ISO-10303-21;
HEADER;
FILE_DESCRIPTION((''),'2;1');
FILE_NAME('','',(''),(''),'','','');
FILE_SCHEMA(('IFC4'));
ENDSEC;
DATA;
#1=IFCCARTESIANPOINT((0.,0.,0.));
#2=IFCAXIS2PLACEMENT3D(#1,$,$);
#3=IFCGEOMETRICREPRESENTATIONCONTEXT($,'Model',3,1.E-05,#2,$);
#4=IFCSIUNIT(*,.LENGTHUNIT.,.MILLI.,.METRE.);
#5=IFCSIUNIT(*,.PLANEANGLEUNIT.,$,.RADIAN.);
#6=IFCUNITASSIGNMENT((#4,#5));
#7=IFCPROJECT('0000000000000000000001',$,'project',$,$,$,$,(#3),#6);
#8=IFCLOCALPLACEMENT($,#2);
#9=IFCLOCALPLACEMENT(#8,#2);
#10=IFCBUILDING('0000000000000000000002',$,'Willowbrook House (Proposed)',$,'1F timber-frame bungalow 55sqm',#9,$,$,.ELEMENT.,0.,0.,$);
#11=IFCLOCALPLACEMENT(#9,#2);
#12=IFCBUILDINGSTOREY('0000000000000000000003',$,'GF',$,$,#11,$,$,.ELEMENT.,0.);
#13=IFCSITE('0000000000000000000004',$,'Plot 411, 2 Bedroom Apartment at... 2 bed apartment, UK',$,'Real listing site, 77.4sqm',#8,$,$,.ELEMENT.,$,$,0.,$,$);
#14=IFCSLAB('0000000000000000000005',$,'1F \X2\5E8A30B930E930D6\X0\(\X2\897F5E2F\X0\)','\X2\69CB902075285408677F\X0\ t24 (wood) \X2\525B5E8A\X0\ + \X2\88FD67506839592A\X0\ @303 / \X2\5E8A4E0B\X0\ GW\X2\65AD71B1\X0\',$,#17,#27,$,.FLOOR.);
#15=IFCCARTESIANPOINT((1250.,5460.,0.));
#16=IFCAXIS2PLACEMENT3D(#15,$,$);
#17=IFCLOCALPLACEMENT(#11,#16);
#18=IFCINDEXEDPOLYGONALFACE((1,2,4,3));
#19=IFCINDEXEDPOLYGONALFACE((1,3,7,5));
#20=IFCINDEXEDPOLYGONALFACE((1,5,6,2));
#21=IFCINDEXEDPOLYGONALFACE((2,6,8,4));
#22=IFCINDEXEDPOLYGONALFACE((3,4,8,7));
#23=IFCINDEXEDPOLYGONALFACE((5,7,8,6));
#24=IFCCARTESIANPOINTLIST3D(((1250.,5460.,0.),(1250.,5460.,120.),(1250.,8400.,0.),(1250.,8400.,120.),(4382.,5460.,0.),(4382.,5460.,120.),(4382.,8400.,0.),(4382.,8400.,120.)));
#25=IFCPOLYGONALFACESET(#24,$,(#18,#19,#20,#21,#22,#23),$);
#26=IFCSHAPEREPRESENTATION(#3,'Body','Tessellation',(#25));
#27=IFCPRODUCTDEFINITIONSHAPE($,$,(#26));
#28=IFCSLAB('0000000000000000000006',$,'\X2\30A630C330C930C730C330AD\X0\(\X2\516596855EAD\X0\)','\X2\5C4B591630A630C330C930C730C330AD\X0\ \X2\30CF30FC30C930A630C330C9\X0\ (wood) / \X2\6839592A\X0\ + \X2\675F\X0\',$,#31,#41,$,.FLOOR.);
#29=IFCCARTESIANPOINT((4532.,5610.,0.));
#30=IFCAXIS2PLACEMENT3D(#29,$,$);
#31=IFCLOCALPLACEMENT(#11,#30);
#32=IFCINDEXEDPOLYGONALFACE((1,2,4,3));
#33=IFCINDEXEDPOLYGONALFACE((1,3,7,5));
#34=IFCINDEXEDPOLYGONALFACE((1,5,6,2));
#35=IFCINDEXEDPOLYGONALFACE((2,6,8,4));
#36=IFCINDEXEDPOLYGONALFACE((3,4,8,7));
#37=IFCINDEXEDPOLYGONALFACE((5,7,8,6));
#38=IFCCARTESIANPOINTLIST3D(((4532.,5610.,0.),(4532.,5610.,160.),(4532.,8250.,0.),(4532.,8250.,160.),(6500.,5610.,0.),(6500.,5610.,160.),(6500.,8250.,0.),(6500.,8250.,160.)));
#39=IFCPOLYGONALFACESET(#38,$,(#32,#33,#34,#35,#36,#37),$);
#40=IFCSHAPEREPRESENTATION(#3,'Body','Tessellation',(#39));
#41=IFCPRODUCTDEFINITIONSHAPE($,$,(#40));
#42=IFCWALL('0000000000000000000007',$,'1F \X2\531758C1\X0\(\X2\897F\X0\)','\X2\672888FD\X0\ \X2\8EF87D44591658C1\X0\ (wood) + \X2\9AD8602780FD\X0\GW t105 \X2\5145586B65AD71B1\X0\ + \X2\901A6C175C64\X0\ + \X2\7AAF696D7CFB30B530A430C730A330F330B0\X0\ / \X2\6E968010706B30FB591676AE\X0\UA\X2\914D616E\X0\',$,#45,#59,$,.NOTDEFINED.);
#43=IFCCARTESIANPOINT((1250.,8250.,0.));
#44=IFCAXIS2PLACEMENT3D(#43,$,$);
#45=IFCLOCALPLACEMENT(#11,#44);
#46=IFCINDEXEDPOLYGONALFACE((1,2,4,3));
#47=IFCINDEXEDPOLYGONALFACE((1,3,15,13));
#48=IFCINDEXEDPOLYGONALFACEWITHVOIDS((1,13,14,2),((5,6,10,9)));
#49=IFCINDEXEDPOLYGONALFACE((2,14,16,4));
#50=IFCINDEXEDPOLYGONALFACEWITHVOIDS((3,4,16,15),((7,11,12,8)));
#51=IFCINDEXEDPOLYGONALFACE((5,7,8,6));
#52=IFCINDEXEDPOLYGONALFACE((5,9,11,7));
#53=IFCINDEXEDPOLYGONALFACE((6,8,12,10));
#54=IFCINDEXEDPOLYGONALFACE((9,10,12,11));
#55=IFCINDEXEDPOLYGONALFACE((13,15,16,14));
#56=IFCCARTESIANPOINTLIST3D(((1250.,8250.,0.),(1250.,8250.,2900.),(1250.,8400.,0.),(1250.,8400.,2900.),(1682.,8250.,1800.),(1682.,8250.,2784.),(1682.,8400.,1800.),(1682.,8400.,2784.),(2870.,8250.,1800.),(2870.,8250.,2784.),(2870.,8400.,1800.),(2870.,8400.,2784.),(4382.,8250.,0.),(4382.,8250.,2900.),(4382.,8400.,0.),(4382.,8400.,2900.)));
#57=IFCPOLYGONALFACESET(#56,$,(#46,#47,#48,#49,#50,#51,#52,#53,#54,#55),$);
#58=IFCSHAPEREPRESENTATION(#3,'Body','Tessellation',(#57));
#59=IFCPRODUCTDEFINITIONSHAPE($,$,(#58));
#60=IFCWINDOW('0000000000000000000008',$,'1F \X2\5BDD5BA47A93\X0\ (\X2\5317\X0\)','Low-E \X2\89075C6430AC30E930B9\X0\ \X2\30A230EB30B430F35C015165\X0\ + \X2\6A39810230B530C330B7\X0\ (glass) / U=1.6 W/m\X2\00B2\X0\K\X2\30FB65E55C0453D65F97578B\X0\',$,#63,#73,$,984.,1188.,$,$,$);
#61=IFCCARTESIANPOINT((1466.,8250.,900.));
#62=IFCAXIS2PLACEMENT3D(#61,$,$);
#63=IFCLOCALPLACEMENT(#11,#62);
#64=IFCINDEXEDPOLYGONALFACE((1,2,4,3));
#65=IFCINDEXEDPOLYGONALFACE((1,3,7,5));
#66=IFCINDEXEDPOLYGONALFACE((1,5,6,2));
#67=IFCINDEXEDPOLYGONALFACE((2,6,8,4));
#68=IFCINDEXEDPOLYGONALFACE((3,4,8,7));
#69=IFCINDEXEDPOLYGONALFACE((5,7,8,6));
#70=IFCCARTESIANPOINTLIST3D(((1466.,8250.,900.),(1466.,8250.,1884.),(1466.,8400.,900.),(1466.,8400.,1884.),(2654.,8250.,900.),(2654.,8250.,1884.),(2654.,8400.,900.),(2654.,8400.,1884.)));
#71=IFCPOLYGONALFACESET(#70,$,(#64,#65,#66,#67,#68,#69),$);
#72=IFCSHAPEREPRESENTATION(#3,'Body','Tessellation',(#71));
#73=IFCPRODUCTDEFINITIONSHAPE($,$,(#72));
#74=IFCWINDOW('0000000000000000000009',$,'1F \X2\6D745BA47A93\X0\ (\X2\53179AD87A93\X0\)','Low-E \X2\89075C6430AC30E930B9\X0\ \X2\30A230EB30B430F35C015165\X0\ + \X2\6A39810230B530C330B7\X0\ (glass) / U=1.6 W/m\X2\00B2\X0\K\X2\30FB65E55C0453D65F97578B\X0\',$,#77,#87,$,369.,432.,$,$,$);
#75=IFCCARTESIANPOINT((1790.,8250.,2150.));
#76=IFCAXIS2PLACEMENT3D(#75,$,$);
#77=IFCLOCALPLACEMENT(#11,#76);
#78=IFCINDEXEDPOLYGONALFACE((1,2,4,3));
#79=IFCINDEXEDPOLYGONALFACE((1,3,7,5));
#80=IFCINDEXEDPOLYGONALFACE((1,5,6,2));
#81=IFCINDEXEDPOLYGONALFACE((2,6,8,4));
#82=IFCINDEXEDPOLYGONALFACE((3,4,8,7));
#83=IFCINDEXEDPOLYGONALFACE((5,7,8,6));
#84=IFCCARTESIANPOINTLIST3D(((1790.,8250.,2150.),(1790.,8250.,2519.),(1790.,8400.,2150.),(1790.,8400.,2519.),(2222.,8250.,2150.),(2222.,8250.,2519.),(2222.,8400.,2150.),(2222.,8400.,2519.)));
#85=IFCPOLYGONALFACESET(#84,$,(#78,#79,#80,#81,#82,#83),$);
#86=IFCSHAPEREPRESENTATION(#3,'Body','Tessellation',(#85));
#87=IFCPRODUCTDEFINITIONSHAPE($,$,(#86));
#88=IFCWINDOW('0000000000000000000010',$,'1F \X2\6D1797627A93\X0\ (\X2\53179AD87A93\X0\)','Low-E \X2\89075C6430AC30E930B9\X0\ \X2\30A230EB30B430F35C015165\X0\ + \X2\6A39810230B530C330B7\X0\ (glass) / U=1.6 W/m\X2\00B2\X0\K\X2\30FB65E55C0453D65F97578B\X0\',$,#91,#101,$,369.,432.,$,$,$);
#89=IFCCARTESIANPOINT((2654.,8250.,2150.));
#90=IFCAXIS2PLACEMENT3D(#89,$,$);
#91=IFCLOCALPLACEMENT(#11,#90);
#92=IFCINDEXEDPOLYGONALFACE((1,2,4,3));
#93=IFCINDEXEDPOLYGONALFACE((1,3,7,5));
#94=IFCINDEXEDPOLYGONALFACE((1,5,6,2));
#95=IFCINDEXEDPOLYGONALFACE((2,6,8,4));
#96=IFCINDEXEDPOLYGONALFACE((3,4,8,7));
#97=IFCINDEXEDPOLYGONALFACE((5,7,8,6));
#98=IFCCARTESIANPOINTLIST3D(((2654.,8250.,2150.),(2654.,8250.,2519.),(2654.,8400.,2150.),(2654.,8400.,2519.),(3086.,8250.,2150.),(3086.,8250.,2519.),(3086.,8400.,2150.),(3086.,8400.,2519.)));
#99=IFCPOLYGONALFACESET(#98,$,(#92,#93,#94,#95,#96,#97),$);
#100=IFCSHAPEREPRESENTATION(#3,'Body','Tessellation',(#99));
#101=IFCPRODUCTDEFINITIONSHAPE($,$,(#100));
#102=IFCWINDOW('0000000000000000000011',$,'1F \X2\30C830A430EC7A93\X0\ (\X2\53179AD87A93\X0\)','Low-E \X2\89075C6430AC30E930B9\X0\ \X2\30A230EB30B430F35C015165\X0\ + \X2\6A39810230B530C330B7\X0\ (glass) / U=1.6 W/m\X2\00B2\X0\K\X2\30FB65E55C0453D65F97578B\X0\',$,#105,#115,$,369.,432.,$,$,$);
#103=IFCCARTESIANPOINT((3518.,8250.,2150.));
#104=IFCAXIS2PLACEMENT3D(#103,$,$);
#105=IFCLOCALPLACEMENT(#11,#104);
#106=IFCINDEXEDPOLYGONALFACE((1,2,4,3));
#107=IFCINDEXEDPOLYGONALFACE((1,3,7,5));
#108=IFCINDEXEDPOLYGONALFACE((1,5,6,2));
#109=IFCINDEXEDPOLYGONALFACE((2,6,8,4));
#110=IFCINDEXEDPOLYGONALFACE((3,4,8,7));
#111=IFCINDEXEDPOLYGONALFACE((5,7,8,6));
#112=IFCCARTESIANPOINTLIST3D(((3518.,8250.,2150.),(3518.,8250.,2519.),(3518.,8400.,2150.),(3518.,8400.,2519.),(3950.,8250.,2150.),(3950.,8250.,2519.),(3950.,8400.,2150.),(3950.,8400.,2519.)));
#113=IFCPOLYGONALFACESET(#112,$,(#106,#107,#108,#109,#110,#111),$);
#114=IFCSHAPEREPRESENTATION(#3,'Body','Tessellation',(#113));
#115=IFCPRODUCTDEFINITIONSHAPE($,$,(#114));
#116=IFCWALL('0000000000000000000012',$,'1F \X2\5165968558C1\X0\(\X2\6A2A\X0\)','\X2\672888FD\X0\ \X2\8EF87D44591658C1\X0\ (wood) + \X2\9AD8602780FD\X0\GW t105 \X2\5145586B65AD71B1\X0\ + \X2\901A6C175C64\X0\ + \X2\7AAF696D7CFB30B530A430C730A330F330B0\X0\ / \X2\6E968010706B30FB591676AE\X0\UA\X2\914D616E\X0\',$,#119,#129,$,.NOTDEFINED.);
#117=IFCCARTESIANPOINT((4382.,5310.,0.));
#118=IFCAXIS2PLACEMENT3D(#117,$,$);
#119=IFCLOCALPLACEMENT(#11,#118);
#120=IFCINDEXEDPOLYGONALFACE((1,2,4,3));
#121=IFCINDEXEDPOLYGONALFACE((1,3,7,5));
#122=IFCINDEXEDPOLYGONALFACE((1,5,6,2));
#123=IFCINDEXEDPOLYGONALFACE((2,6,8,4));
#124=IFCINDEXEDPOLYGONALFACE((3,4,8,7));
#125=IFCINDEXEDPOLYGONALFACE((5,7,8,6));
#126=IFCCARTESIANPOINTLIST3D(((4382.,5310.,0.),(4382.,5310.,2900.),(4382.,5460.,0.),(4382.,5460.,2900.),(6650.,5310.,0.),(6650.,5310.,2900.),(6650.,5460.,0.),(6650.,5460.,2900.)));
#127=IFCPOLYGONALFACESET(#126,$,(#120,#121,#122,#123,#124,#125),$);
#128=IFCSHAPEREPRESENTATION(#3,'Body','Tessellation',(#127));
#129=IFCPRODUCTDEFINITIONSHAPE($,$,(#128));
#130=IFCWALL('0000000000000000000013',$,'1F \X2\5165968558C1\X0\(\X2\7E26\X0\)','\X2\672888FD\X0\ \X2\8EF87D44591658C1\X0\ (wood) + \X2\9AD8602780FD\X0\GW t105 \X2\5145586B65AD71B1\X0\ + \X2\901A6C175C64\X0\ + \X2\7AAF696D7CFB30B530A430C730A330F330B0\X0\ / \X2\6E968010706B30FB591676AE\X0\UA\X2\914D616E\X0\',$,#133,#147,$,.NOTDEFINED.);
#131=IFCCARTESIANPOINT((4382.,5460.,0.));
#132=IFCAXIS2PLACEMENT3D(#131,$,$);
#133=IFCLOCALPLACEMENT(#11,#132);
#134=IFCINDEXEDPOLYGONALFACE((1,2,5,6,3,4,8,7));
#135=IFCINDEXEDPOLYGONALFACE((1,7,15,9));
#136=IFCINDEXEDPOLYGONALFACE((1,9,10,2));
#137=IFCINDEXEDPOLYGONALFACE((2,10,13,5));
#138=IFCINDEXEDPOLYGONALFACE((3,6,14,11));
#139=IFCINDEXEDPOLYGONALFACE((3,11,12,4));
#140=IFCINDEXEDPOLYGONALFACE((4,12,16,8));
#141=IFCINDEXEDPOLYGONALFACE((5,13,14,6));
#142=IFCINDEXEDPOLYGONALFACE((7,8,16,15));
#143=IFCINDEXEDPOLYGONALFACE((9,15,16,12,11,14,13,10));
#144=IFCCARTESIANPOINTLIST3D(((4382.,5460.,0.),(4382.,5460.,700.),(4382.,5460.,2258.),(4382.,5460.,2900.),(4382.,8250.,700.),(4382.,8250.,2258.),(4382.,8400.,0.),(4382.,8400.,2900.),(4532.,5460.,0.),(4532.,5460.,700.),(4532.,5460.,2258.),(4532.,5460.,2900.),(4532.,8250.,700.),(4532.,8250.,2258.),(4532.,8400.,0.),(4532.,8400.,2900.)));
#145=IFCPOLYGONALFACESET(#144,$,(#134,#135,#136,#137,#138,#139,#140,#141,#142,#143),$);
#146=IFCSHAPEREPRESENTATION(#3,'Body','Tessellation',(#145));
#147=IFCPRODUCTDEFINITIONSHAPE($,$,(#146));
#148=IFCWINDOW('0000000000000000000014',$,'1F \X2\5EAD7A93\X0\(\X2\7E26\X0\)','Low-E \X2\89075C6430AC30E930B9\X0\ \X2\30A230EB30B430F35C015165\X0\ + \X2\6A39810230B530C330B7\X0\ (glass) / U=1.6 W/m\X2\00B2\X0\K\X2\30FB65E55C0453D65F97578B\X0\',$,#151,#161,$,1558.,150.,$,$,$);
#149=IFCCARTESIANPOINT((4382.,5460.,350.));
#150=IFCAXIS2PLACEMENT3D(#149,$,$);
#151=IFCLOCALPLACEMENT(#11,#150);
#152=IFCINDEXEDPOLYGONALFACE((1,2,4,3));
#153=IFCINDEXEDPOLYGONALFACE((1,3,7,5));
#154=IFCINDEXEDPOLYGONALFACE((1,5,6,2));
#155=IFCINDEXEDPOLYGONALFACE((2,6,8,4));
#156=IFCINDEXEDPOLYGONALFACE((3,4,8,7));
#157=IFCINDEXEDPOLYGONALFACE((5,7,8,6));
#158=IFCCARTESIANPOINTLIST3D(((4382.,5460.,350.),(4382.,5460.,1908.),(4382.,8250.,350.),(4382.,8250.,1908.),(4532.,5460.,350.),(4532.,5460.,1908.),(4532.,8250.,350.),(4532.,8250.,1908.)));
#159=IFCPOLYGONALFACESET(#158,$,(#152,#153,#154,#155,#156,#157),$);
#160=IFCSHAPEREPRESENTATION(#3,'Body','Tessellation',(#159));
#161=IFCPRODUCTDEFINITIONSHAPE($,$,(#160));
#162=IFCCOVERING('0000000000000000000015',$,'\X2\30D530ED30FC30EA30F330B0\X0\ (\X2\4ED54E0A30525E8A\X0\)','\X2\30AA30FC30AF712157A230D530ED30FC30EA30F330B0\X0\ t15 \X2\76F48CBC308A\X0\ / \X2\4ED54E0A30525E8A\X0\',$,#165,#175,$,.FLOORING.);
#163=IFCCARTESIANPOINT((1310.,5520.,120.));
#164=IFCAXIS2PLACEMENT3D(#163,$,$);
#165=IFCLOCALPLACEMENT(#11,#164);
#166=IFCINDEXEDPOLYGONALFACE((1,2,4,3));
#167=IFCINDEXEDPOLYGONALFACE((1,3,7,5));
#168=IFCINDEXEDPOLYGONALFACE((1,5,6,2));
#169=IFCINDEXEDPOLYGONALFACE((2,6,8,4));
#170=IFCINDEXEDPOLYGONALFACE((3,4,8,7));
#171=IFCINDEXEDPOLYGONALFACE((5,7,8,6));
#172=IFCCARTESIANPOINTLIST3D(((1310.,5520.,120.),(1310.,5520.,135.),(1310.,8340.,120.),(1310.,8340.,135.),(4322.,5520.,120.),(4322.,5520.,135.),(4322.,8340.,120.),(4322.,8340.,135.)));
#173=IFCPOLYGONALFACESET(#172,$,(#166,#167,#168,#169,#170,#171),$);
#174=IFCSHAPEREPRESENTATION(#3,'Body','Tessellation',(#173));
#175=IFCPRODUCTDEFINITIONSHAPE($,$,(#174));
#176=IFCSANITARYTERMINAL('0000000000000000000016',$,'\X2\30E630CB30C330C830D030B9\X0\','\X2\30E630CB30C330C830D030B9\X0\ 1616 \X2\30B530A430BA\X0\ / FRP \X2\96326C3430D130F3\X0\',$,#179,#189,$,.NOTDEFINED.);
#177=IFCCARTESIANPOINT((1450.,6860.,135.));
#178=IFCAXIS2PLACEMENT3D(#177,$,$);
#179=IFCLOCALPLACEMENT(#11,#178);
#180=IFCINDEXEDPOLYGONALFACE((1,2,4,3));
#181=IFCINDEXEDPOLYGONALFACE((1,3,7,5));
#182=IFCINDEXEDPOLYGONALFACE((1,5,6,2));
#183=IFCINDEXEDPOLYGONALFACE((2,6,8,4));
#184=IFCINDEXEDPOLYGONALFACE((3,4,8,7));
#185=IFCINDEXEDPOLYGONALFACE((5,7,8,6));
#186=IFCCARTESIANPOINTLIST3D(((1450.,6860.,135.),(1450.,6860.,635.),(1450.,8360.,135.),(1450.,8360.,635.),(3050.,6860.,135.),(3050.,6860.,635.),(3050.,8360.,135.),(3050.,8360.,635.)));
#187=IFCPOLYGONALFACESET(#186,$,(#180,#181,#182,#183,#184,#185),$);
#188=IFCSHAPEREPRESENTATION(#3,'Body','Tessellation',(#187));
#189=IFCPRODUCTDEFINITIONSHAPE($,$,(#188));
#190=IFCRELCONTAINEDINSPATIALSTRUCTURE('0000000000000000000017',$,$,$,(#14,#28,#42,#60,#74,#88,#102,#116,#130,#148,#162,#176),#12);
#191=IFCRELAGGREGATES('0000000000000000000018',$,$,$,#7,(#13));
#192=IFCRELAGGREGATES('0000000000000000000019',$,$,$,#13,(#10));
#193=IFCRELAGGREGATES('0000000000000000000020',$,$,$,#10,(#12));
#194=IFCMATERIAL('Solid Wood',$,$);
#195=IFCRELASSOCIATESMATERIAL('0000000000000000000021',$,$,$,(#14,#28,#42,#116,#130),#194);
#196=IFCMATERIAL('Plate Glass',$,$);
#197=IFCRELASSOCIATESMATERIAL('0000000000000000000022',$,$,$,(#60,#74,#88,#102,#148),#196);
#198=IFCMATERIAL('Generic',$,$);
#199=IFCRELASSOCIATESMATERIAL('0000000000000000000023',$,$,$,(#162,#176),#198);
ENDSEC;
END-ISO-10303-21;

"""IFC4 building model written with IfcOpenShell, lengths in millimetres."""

from ifc_helpers import new_model, si_unit, frame, frame_2d, origin, place, context, project, spatial, rectangle, extrude, material, element, fill, save


model = new_model("IFC4")

# Units and contexts
model_context = context("Model", 3, precision=1e-05, world=origin())
ifc_project = project(units=[si_unit("LENGTHUNIT", "METRE", prefix="MILLI"), si_unit("PLANEANGLEUNIT", "RADIAN")], contexts=[model_context])

# Site, building, storey
site_placement = place(None, origin())
site = spatial("IfcSite", under=ifc_project, at=site_placement, Name="Plot 411, 2 Bedroom Apartment at... 2 bed apartment, UK", ObjectType="Real listing site, 77.4sqm", CompositionType="ELEMENT", RefElevation=0.0)
building_placement = place(site_placement, origin())
building = spatial("IfcBuilding", under=site, at=building_placement, Name="Willowbrook House (Proposed)", ObjectType="1F timber-frame bungalow 55sqm", CompositionType="ELEMENT", ElevationOfRefHeight=0.0, ElevationOfTerrain=0.0)
storey_placement = place(building_placement, origin())
storey = spatial("IfcBuildingStorey", under=building, at=storey_placement, Name="GF", CompositionType="ELEMENT", Elevation=0.0)

# Slabs
ifc_material_1 = material(Name="Solid Wood")
slab_1_placement = place(storey_placement, frame((1250.0, 5460.0, 0.0)))
element("IfcSlab", 1, at=slab_1_placement, inside=storey, material=ifc_material_1, Name="1F 床スラブ(西帯)", Description="構造用合板 t24 (wood) 剛床 + 製材根太 @303 / 床下 GW断熱", PredefinedType="FLOOR", context=model_context, shape_type="SweptSolid", body=[
    extrude(rectangle(XDim=3132.0, YDim=2940.0, at=frame_2d((1566.0, 1470.0))), frame((1250.0, 5460.0, 0.0)), (0.0, 0.0, 1.0), 120.0),
])
slab_2_placement = place(storey_placement, frame((4532.0, 5610.0, 0.0)))
element("IfcSlab", 2, at=slab_2_placement, inside=storey, material=ifc_material_1, Name="ウッドデッキ(入隅庭)", Description="屋外ウッドデッキ ハードウッド (wood) / 根太 + 束", PredefinedType="FLOOR", context=model_context, shape_type="SweptSolid", body=[
    extrude(rectangle(XDim=1968.0, YDim=2640.0, at=frame_2d((984.0, 1320.0))), frame((4532.0, 5610.0, 0.0)), (0.0, 0.0, 1.0), 160.0),
])

# Wall, openings, windows
wall_1_placement = place(storey_placement, frame((1250.0, 8250.0, 0.0)))
wall_1 = element("IfcWall", 3, at=wall_1_placement, inside=storey, material=ifc_material_1, Name="1F 北壁(西)", Description="木製 軸組外壁 (wood) + 高性能GW t105 充填断熱 + 通気層 + 窯業系サイディング / 準耐火・外皮UA配慮", PredefinedType="NOTDEFINED", context=model_context, shape_type="SweptSolid", body=[
    extrude(rectangle(XDim=3132.0, YDim=150.0, at=frame_2d((1566.0, 75.0))), frame((1250.0, 8250.0, 0.0)), (0.0, 0.0, 1.0), 2900.0),
])
opening_1_placement = place(storey_placement, frame((1466.0, 8250.0, 900.0)))
opening_1 = element("IfcOpeningElement", 4, at=opening_1_placement, cuts=wall_1, PredefinedType="NOTDEFINED", context=model_context, shape_type="SweptSolid", body=[
    extrude(rectangle(XDim=1188.0, YDim=150.0, at=frame_2d((594.0, 75.0))), frame((1466.0, 8250.0, 900.0)), (0.0, 0.0, 1.0), 984.0),
])
opening_2_placement = place(storey_placement, frame((1790.0, 8250.0, 2150.0)))
opening_2 = element("IfcOpeningElement", 5, at=opening_2_placement, cuts=wall_1, PredefinedType="NOTDEFINED", context=model_context, shape_type="SweptSolid", body=[
    extrude(rectangle(XDim=432.0, YDim=150.0, at=frame_2d((216.0, 75.0))), frame((1790.0, 8250.0, 2150.0)), (0.0, 0.0, 1.0), 369.0),
])
opening_3_placement = place(storey_placement, frame((2654.0, 8250.0, 2150.0)))
opening_3 = element("IfcOpeningElement", 6, at=opening_3_placement, cuts=wall_1, PredefinedType="NOTDEFINED", context=model_context, shape_type="SweptSolid", body=[
    extrude(rectangle(XDim=432.0, YDim=150.0, at=frame_2d((216.0, 75.0))), frame((2654.0, 8250.0, 2150.0)), (0.0, 0.0, 1.0), 369.0),
])
opening_4_placement = place(storey_placement, frame((3518.0, 8250.0, 2150.0)))
opening_4 = element("IfcOpeningElement", 7, at=opening_4_placement, cuts=wall_1, PredefinedType="NOTDEFINED", context=model_context, shape_type="SweptSolid", body=[
    extrude(rectangle(XDim=432.0, YDim=150.0, at=frame_2d((216.0, 75.0))), frame((3518.0, 8250.0, 2150.0)), (0.0, 0.0, 1.0), 369.0),
])
ifc_material_2 = material(Name="Plate Glass")
window_1_placement = place(storey_placement, frame((1466.0, 8250.0, 900.0)))
window_1 = element("IfcWindow", 8, at=window_1_placement, inside=storey, material=ifc_material_2, Name="1F 寝室窓 (北)", Description="Low-E 複層ガラス アルゴン封入 + 樹脂サッシ (glass) / U=1.6 W/m²K・日射取得型", OverallHeight=984.0, OverallWidth=1188.0, context=model_context, shape_type="SweptSolid", body=[
    extrude(rectangle(XDim=1188.0, YDim=150.0, at=frame_2d((594.0, 75.0))), frame((1466.0, 8250.0, 900.0)), (0.0, 0.0, 1.0), 984.0),
])
fill(opening_1, window_1)
window_2_placement = place(storey_placement, frame((1790.0, 8250.0, 2150.0)))
window_2 = element("IfcWindow", 9, at=window_2_placement, inside=storey, material=ifc_material_2, Name="1F 浴室窓 (北高窓)", Description="Low-E 複層ガラス アルゴン封入 + 樹脂サッシ (glass) / U=1.6 W/m²K・日射取得型", OverallHeight=369.0, OverallWidth=432.0, context=model_context, shape_type="SweptSolid", body=[
    extrude(rectangle(XDim=432.0, YDim=150.0, at=frame_2d((216.0, 75.0))), frame((1790.0, 8250.0, 2150.0)), (0.0, 0.0, 1.0), 369.0),
])
fill(opening_2, window_2)
window_3_placement = place(storey_placement, frame((2654.0, 8250.0, 2150.0)))
window_3 = element("IfcWindow", 10, at=window_3_placement, inside=storey, material=ifc_material_2, Name="1F 洗面窓 (北高窓)", Description="Low-E 複層ガラス アルゴン封入 + 樹脂サッシ (glass) / U=1.6 W/m²K・日射取得型", OverallHeight=369.0, OverallWidth=432.0, context=model_context, shape_type="SweptSolid", body=[
    extrude(rectangle(XDim=432.0, YDim=150.0, at=frame_2d((216.0, 75.0))), frame((2654.0, 8250.0, 2150.0)), (0.0, 0.0, 1.0), 369.0),
])
fill(opening_3, window_3)
window_4_placement = place(storey_placement, frame((3518.0, 8250.0, 2150.0)))
window_4 = element("IfcWindow", 11, at=window_4_placement, inside=storey, material=ifc_material_2, Name="1F トイレ窓 (北高窓)", Description="Low-E 複層ガラス アルゴン封入 + 樹脂サッシ (glass) / U=1.6 W/m²K・日射取得型", OverallHeight=369.0, OverallWidth=432.0, context=model_context, shape_type="SweptSolid", body=[
    extrude(rectangle(XDim=432.0, YDim=150.0, at=frame_2d((216.0, 75.0))), frame((3518.0, 8250.0, 2150.0)), (0.0, 0.0, 1.0), 369.0),
])
fill(opening_4, window_4)

# Wall
wall_2_placement = place(storey_placement, frame((4382.0, 5310.0, 0.0)))
element("IfcWall", 12, at=wall_2_placement, inside=storey, material=ifc_material_1, Name="1F 入隅壁(横)", Description="木製 軸組外壁 (wood) + 高性能GW t105 充填断熱 + 通気層 + 窯業系サイディング / 準耐火・外皮UA配慮", PredefinedType="NOTDEFINED", context=model_context, shape_type="SweptSolid", body=[
    extrude(rectangle(XDim=2268.0, YDim=150.0, at=frame_2d((1134.0, 75.0))), frame((4382.0, 5310.0, 0.0)), (0.0, 0.0, 1.0), 2900.0),
])

# Wall, opening, window
wall_3_placement = place(storey_placement, frame((4382.0, 5460.0, 0.0)))
wall_3 = element("IfcWall", 13, at=wall_3_placement, inside=storey, material=ifc_material_1, Name="1F 入隅壁(縦)", Description="木製 軸組外壁 (wood) + 高性能GW t105 充填断熱 + 通気層 + 窯業系サイディング / 準耐火・外皮UA配慮", PredefinedType="NOTDEFINED", context=model_context, shape_type="SweptSolid", body=[
    extrude(rectangle(XDim=150.0, YDim=2940.0, at=frame_2d((75.0, 1470.0))), frame((4382.0, 5460.0, 0.0)), (0.0, 0.0, 1.0), 2900.0),
])
opening_5_placement = place(storey_placement, frame((4382.0, 5460.0, 350.0)))
opening_5 = element("IfcOpeningElement", 14, at=opening_5_placement, cuts=wall_3, PredefinedType="NOTDEFINED", context=model_context, shape_type="SweptSolid", body=[
    extrude(rectangle(XDim=150.0, YDim=2790.0, at=frame_2d((75.0, 1395.0))), frame((4382.0, 5460.0, 350.0)), (0.0, 0.0, 1.0), 1558.0),
])
window_5_placement = place(storey_placement, frame((4382.0, 5460.0, 350.0)))
window_5 = element("IfcWindow", 15, at=window_5_placement, inside=storey, material=ifc_material_2, Name="1F 庭窓(縦)", Description="Low-E 複層ガラス アルゴン封入 + 樹脂サッシ (glass) / U=1.6 W/m²K・日射取得型", OverallHeight=1558.0, OverallWidth=150.0, context=model_context, shape_type="SweptSolid", body=[
    extrude(rectangle(XDim=150.0, YDim=2790.0, at=frame_2d((75.0, 1395.0))), frame((4382.0, 5460.0, 350.0)), (0.0, 0.0, 1.0), 1558.0),
])
fill(opening_5, window_5)

# Covering
ifc_material_3 = material(Name="Generic")
covering_placement = place(storey_placement, frame((1310.0, 5520.0, 120.0)))
element("IfcCovering", 16, at=covering_placement, inside=storey, material=ifc_material_3, Name="フローリング (仕上げ床)", Description="オーク無垢フローリング t15 直貼り / 仕上げ床", PredefinedType="FLOORING", context=model_context, shape_type="SweptSolid", body=[
    extrude(rectangle(XDim=3012.0, YDim=2820.0, at=frame_2d((1506.0, 1410.0))), frame((1310.0, 5520.0, 120.0)), (0.0, 0.0, 1.0), 15.0),
])

# Sanitary terminal
sanitary_terminal_1_placement = place(storey_placement, frame((1450.0, 6860.0, 135.0)))
element("IfcSanitaryTerminal", 17, at=sanitary_terminal_1_placement, inside=storey, material=ifc_material_3, Name="ユニットバス", Description="ユニットバス 1616 サイズ / FRP 防水パン", PredefinedType="NOTDEFINED", context=model_context, shape_type="SweptSolid", body=[
    extrude(rectangle(XDim=1600.0, YDim=1500.0, at=frame_2d((800.0, 750.0))), frame((1450.0, 6860.0, 135.0)), (0.0, 0.0, 1.0), 500.0),
])

save(model, "model.ifc")
